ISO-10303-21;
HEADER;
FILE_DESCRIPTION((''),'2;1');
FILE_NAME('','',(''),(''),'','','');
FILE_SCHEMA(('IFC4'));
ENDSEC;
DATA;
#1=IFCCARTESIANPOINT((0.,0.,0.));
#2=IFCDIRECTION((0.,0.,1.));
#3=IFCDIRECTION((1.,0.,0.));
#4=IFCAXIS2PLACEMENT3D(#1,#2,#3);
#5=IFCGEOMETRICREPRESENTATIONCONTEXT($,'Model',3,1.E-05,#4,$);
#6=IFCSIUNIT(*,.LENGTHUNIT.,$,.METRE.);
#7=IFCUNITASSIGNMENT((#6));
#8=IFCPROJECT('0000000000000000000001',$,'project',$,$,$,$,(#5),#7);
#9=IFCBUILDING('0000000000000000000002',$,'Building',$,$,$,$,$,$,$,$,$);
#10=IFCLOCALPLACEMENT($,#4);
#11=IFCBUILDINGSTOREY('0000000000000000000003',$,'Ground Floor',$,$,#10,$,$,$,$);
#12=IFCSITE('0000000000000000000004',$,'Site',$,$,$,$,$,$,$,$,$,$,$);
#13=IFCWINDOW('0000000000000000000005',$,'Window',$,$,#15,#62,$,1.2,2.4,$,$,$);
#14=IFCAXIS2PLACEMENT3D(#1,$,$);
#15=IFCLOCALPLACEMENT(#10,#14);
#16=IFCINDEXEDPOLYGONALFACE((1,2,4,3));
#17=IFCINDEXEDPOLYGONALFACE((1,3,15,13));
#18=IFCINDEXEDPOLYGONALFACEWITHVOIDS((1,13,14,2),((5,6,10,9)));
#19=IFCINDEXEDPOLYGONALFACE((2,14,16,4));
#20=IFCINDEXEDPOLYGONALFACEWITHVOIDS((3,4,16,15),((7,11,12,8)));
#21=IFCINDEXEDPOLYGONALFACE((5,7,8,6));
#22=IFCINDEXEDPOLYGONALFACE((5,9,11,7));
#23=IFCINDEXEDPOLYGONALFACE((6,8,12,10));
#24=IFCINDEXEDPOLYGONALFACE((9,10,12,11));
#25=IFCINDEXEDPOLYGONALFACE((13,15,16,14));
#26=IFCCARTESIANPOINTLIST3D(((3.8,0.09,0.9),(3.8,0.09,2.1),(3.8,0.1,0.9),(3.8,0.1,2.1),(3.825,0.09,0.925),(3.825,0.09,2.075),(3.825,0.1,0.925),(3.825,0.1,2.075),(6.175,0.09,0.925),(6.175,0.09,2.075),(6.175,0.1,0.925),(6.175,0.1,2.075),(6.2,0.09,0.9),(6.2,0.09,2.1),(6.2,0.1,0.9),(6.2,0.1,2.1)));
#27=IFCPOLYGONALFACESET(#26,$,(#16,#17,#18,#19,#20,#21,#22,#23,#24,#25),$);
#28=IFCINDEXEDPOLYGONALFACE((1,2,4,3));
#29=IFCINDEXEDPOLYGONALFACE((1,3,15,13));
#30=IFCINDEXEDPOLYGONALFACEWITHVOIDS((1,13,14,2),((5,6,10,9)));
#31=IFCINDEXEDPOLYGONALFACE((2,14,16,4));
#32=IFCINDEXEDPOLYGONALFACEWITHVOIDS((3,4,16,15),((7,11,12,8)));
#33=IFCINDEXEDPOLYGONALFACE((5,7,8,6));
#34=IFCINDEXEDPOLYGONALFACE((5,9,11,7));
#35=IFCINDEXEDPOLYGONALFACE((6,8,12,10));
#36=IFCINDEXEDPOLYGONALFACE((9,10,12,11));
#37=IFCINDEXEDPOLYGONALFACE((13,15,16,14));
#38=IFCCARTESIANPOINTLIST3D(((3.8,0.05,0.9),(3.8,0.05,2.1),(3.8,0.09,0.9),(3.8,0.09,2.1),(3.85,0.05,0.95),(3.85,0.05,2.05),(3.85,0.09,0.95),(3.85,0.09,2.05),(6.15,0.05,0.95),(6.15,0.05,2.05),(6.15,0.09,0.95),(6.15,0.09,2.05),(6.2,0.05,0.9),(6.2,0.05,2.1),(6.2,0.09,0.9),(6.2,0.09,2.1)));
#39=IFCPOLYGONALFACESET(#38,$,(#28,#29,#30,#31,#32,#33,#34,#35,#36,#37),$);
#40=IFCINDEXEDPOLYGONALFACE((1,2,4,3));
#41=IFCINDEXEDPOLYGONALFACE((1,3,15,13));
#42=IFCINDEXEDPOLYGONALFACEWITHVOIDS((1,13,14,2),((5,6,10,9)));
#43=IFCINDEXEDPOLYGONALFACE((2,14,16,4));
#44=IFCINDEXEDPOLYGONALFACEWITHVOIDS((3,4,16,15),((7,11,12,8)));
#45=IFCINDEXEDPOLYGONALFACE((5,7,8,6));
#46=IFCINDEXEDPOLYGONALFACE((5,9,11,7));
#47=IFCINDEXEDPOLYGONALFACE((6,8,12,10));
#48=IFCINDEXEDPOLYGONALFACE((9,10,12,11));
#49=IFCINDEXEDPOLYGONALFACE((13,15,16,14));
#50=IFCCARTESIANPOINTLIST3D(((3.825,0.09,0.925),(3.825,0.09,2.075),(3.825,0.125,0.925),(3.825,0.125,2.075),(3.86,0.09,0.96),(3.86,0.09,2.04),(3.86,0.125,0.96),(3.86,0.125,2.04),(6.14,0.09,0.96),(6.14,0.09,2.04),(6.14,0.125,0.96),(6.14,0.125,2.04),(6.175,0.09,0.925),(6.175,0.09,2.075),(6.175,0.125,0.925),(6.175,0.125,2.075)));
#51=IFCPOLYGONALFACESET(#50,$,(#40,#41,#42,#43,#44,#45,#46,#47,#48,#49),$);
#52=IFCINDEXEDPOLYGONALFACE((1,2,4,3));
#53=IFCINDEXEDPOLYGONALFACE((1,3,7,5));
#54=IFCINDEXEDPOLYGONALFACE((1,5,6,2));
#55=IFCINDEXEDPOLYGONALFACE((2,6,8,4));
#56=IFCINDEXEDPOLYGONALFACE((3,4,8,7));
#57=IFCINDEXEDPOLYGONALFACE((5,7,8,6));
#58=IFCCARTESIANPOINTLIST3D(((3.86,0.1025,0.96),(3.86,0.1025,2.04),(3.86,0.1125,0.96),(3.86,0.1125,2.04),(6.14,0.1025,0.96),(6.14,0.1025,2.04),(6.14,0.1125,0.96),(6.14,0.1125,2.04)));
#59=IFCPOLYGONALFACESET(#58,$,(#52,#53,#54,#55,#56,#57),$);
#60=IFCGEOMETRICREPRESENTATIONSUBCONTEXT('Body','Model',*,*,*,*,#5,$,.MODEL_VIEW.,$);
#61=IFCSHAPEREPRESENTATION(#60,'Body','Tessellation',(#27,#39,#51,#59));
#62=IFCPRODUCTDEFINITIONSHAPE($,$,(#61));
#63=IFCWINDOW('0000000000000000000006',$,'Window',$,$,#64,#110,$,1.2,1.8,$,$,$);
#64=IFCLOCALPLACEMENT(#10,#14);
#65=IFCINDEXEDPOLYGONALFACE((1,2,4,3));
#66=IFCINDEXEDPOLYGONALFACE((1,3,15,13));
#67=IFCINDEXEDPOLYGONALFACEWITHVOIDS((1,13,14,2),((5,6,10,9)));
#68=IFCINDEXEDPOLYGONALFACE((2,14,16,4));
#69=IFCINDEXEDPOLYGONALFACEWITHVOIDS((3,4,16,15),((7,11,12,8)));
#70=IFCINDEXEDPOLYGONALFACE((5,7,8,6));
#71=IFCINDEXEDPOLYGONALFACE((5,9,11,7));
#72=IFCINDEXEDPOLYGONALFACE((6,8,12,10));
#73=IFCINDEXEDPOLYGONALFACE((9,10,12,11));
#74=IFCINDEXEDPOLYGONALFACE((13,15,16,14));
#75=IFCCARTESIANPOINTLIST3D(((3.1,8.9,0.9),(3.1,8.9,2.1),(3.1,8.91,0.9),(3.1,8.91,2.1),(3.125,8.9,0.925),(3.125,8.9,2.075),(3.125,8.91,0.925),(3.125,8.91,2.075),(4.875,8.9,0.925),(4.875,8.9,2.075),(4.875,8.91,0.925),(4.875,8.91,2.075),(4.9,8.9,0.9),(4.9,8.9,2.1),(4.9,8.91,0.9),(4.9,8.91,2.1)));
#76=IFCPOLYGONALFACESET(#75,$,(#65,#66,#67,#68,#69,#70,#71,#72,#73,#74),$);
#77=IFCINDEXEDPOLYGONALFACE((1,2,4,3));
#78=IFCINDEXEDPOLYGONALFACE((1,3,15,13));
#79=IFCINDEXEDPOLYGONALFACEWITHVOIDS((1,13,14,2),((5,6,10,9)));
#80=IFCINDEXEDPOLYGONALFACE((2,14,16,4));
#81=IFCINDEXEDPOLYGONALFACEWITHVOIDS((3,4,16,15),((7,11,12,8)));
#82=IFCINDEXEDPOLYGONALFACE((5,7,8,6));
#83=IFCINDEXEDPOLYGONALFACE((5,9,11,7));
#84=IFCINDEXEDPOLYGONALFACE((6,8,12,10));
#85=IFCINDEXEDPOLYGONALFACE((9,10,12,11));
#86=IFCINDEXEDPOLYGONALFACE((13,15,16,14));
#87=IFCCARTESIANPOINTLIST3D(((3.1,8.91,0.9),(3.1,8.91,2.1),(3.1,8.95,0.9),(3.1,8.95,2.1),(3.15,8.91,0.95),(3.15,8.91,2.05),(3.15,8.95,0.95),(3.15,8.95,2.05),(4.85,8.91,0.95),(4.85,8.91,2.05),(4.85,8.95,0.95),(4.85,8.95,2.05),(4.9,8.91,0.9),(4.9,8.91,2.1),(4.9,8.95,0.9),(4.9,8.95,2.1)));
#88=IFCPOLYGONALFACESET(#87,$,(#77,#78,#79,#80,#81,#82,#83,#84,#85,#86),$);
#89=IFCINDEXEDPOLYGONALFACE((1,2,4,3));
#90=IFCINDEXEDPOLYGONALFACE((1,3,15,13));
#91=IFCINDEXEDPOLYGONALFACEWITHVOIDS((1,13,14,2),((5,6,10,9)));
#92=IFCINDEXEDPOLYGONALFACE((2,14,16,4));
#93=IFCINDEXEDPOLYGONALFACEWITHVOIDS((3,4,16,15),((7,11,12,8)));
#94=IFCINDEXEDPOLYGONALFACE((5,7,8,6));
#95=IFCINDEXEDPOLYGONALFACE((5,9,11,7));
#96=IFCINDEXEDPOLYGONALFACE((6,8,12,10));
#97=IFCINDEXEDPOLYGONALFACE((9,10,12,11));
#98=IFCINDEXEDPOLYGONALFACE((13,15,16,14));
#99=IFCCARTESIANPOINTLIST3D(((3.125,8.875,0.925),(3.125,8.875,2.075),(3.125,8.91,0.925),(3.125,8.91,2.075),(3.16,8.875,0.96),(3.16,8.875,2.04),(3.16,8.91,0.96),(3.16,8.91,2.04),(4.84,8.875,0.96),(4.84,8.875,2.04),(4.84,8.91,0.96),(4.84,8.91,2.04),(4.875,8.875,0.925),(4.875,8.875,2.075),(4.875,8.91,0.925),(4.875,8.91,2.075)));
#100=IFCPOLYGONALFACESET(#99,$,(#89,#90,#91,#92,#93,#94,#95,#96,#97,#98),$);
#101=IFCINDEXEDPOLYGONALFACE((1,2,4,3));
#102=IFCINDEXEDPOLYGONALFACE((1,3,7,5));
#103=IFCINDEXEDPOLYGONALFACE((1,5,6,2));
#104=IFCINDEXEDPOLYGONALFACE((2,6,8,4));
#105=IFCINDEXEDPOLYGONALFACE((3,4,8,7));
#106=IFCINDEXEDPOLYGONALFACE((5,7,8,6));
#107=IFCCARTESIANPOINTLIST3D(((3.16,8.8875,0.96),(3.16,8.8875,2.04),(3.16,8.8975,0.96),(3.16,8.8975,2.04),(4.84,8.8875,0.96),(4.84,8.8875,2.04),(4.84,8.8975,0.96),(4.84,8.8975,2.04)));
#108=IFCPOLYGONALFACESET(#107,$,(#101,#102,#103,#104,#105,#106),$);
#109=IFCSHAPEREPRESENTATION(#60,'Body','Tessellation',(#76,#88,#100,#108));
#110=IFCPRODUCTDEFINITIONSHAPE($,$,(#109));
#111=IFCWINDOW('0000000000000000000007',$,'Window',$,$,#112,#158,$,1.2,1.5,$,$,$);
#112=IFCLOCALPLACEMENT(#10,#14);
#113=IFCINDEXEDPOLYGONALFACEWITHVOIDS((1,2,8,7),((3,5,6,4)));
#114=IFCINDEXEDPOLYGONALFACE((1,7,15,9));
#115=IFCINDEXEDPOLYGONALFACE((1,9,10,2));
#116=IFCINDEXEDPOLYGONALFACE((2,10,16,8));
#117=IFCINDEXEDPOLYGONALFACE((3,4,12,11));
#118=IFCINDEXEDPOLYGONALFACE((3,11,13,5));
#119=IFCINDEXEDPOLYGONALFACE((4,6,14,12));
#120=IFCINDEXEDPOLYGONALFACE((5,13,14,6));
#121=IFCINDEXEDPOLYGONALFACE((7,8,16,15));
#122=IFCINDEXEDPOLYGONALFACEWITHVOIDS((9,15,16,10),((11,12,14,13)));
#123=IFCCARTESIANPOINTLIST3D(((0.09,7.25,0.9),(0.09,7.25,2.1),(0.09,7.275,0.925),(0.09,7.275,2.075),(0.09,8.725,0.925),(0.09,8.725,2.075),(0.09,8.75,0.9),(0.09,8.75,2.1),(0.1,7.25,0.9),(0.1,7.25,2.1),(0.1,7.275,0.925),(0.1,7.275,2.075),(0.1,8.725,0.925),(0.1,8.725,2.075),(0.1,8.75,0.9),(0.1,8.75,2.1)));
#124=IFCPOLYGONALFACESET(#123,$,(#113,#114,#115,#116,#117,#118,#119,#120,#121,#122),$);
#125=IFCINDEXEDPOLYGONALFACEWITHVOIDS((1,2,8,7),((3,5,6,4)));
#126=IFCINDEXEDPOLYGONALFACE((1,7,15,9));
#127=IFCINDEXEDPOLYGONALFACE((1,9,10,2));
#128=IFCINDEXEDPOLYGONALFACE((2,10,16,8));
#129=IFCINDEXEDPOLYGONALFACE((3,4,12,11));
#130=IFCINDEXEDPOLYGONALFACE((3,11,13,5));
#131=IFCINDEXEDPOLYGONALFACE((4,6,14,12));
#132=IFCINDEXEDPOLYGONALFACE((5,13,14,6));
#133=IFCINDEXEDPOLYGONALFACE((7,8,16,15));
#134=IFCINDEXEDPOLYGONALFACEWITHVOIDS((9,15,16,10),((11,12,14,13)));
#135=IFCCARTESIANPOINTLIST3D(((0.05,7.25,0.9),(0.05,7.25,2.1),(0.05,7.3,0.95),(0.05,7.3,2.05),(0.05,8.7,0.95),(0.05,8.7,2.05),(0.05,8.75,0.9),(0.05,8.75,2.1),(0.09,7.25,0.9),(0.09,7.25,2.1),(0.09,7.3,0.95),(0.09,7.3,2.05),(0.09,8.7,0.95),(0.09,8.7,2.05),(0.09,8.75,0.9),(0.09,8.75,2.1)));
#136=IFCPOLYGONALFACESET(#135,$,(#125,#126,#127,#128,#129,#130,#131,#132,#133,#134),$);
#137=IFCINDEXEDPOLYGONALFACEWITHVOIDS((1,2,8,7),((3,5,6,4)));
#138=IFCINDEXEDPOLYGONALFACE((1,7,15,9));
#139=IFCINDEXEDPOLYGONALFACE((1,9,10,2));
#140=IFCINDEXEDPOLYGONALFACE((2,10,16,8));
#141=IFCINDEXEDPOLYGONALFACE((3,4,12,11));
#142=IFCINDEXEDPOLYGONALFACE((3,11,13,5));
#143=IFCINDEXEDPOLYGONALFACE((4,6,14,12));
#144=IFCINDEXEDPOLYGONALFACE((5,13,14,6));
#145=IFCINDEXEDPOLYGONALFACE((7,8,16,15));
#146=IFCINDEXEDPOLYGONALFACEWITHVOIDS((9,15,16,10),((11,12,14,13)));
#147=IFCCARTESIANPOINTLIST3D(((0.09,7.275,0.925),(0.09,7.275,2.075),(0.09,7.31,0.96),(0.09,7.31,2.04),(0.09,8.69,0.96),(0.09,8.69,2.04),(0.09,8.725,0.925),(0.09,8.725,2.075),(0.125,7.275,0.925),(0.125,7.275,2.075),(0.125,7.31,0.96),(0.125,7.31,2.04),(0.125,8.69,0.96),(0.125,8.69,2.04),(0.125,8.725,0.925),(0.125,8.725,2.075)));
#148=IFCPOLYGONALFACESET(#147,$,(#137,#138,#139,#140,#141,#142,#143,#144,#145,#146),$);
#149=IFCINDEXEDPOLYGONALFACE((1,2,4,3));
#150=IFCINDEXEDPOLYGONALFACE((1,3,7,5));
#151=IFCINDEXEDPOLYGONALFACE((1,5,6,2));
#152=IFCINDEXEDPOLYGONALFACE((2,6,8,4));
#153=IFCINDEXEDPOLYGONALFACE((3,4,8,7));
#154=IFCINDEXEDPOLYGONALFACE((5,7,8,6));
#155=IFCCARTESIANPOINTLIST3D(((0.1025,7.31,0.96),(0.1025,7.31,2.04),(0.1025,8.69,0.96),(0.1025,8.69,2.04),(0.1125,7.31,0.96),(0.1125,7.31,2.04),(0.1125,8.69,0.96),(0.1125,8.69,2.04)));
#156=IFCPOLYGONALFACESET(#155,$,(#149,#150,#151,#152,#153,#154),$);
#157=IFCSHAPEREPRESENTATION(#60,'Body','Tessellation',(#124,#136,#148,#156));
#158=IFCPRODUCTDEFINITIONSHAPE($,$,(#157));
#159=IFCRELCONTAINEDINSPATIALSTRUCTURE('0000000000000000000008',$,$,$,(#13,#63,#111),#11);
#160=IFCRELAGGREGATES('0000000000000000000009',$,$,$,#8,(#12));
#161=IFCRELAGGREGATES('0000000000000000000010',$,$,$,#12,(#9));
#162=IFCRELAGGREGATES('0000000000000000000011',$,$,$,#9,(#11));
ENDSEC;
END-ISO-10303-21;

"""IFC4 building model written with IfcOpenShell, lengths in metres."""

from ifc_helpers import new_model, si_unit, frame, origin_with_axes, place, context, subcontext, project, spatial, line, indexed_curve, outline, extrude, element, save


model = new_model("IFC4")

# Units and contexts
model_context = context("Model", 3, precision=1e-05, world=origin_with_axes())
body_context = subcontext(model_context, "Body", "Model", "MODEL_VIEW")
ifc_project = project(units=[si_unit("LENGTHUNIT", "METRE")], contexts=[model_context])

# Site, building, storey
site = spatial("IfcSite", under=ifc_project, Name="Site")
building = spatial("IfcBuilding", under=site, Name="Building")
storey_placement = place(None, origin_with_axes())
storey = spatial("IfcBuildingStorey", under=building, at=storey_placement, Name="Ground Floor")

# Windows
window_1_placement = place(storey_placement, frame((3.8, 0.0, 0.9), z_axis=(0.0, 0.0, 1.0), x_axis=(1.0, 0.0, 0.0)))
element("IfcWindow", 1, at=window_1_placement, inside=storey, Name="Window", OverallHeight=1.2, OverallWidth=2.4, context=body_context, shape_type="SweptSolid", body=[
    extrude(outline(indexed_curve([(0.0, 0.0), (2.4, 0.0), (2.4, 1.2), (0.0, 1.2)], segments=[line(1, 2, 3, 4, 1)]), holes=[indexed_curve([(0.025, 0.025), (2.375, 0.025), (2.375, 1.175), (0.025, 1.175)], segments=[line(1, 2, 3, 4, 1)])]), frame((0.0, 0.09, 0.0), z_axis=(0.0, -1.0, 0.0), x_axis=(1.0, 0.0, 0.0)), (0.0, 0.0, -1.0), 0.01),
    extrude(outline(indexed_curve([(0.0, 0.0), (2.4, 0.0), (2.4, 1.2), (0.0, 1.2)], segments=[line(1, 2, 3, 4, 1)]), holes=[indexed_curve([(0.05, 0.05), (2.35, 0.05), (2.35, 1.15), (0.05, 1.15)], segments=[line(1, 2, 3, 4, 1)])]), frame((0.0, 0.05, 0.0), z_axis=(0.0, -1.0, 0.0), x_axis=(1.0, 0.0, 0.0)), (0.0, 0.0, -1.0), 0.04),
    extrude(outline(indexed_curve([(0.0, 0.0), (2.35, 0.0), (2.35, 1.15), (0.0, 1.15)], segments=[line(1, 2, 3, 4, 1)]), holes=[indexed_curve([(0.035, 0.035), (2.315, 0.035), (2.315, 1.115), (0.035, 1.115)], segments=[line(1, 2, 3, 4, 1)])]), frame((0.025, 0.09, 0.025), z_axis=(0.0, -1.0, 0.0), x_axis=(1.0, 0.0, 0.0)), (0.0, 0.0, -1.0), 0.035),
    extrude(outline(indexed_curve([(0.035, 0.035), (2.315, 0.035), (2.315, 1.115), (0.035, 1.115)], segments=[line(1, 2, 3, 4, 1)])), frame((0.025, 0.1025, 0.025), z_axis=(0.0, -1.0, 0.0), x_axis=(1.0, 0.0, 0.0)), (0.0, 0.0, -1.0), 0.01),
])
window_2_placement = place(storey_placement, frame((4.9, 9.0, 0.9), z_axis=(0.0, 0.0, 1.0), x_axis=(-1.0, 0.0, 0.0)))
element("IfcWindow", 2, at=window_2_placement, inside=storey, Name="Window", OverallHeight=1.2, OverallWidth=1.8, context=body_context, shape_type="SweptSolid", body=[
    extrude(outline(indexed_curve([(0.0, 0.0), (1.8, 0.0), (1.8, 1.2), (0.0, 1.2)], segments=[line(1, 2, 3, 4, 1)]), holes=[indexed_curve([(0.025, 0.025), (1.775, 0.025), (1.775, 1.175), (0.025, 1.175)], segments=[line(1, 2, 3, 4, 1)])]), frame((0.0, 0.09, 0.0), z_axis=(0.0, -1.0, 0.0), x_axis=(1.0, 0.0, 0.0)), (0.0, 0.0, -1.0), 0.01),
    extrude(outline(indexed_curve([(0.0, 0.0), (1.8, 0.0), (1.8, 1.2), (0.0, 1.2)], segments=[line(1, 2, 3, 4, 1)]), holes=[indexed_curve([(0.05, 0.05), (1.75, 0.05), (1.75, 1.15), (0.05, 1.15)], segments=[line(1, 2, 3, 4, 1)])]), frame((0.0, 0.05, 0.0), z_axis=(0.0, -1.0, 0.0), x_axis=(1.0, 0.0, 0.0)), (0.0, 0.0, -1.0), 0.04),
    extrude(outline(indexed_curve([(0.0, 0.0), (1.75, 0.0), (1.75, 1.15), (0.0, 1.15)], segments=[line(1, 2, 3, 4, 1)]), holes=[indexed_curve([(0.035, 0.035), (1.715, 0.035), (1.715, 1.115), (0.035, 1.115)], segments=[line(1, 2, 3, 4, 1)])]), frame((0.025, 0.09, 0.025), z_axis=(0.0, -1.0, 0.0), x_axis=(1.0, 0.0, 0.0)), (0.0, 0.0, -1.0), 0.035),
    extrude(outline(indexed_curve([(0.035, 0.035), (1.715, 0.035), (1.715, 1.115), (0.035, 1.115)], segments=[line(1, 2, 3, 4, 1)])), frame((0.025, 0.1025, 0.025), z_axis=(0.0, -1.0, 0.0), x_axis=(1.0, 0.0, 0.0)), (0.0, 0.0, -1.0), 0.01),
])
window_3_placement = place(storey_placement, frame((0.0, 8.75, 0.9), z_axis=(0.0, 0.0, 1.0), x_axis=(0.0, -1.0, 0.0)))
element("IfcWindow", 3, at=window_3_placement, inside=storey, Name="Window", OverallHeight=1.2, OverallWidth=1.5, context=body_context, shape_type="SweptSolid", body=[
    extrude(outline(indexed_curve([(0.0, 0.0), (1.5, 0.0), (1.5, 1.2), (0.0, 1.2)], segments=[line(1, 2, 3, 4, 1)]), holes=[indexed_curve([(0.025, 0.025), (1.475, 0.025), (1.475, 1.175), (0.025, 1.175)], segments=[line(1, 2, 3, 4, 1)])]), frame((0.0, 0.09, 0.0), z_axis=(0.0, -1.0, 0.0), x_axis=(1.0, 0.0, 0.0)), (0.0, 0.0, -1.0), 0.01),
    extrude(outline(indexed_curve([(0.0, 0.0), (1.5, 0.0), (1.5, 1.2), (0.0, 1.2)], segments=[line(1, 2, 3, 4, 1)]), holes=[indexed_curve([(0.05, 0.05), (1.45, 0.05), (1.45, 1.15), (0.05, 1.15)], segments=[line(1, 2, 3, 4, 1)])]), frame((0.0, 0.05, 0.0), z_axis=(0.0, -1.0, 0.0), x_axis=(1.0, 0.0, 0.0)), (0.0, 0.0, -1.0), 0.04),
    extrude(outline(indexed_curve([(0.0, 0.0), (1.45, 0.0), (1.45, 1.15), (0.0, 1.15)], segments=[line(1, 2, 3, 4, 1)]), holes=[indexed_curve([(0.035, 0.035), (1.415, 0.035), (1.415, 1.115), (0.035, 1.115)], segments=[line(1, 2, 3, 4, 1)])]), frame((0.025, 0.09, 0.025), z_axis=(0.0, -1.0, 0.0), x_axis=(1.0, 0.0, 0.0)), (0.0, 0.0, -1.0), 0.035),
    extrude(outline(indexed_curve([(0.035, 0.035), (1.415, 0.035), (1.415, 1.115), (0.035, 1.115)], segments=[line(1, 2, 3, 4, 1)])), frame((0.025, 0.1025, 0.025), z_axis=(0.0, -1.0, 0.0), x_axis=(1.0, 0.0, 0.0)), (0.0, 0.0, -1.0), 0.01),
])

save(model, "model.ifc")
